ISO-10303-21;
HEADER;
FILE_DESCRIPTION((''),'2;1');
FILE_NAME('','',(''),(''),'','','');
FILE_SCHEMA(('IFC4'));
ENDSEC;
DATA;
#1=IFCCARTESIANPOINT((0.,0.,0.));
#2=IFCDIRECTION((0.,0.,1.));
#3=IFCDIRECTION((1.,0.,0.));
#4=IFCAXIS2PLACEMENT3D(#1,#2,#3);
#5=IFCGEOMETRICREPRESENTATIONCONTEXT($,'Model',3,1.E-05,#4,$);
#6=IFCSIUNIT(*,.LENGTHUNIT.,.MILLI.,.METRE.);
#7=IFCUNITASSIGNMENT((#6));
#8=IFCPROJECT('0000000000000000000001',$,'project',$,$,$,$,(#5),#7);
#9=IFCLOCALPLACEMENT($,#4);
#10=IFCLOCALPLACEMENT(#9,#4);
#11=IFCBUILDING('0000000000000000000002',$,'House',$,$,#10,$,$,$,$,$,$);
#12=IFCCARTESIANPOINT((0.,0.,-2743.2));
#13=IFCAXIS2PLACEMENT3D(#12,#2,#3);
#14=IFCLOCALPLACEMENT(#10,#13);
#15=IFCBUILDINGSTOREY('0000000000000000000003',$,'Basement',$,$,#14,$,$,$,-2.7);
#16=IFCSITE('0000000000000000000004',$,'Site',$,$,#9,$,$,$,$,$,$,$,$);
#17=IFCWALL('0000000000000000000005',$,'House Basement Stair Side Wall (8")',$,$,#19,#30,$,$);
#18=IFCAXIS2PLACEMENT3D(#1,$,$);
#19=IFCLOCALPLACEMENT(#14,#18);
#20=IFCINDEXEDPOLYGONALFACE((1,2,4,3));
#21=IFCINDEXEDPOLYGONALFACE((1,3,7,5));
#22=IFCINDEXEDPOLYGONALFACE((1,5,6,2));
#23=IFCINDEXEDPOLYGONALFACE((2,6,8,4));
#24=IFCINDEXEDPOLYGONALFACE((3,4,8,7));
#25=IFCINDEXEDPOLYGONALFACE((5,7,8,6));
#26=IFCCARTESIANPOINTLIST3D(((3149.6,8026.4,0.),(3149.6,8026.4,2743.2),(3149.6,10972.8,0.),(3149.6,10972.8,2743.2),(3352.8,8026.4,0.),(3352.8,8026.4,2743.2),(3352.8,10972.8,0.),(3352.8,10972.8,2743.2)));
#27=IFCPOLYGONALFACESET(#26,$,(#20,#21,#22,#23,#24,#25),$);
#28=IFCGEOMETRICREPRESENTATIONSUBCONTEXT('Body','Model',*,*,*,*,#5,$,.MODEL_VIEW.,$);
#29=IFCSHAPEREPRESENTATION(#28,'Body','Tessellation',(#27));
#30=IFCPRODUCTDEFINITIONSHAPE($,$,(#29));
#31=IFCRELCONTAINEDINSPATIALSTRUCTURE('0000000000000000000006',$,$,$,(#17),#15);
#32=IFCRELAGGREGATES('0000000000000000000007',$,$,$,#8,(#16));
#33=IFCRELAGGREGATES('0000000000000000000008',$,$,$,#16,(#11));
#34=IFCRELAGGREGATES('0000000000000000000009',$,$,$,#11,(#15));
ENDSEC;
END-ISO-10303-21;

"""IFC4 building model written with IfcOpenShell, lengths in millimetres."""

from ifc_helpers import new_model, si_unit, frame, origin_with_axes, place, context, subcontext, project, spatial, indexed_curve, outline, extrude, element, save


model = new_model("IFC4")

# Units and contexts
model_context = context("Model", 3, precision=1e-05, world=origin_with_axes())
body_context = subcontext(model_context, "Body", "Model", "MODEL_VIEW")
ifc_project = project(units=[si_unit("LENGTHUNIT", "METRE", prefix="MILLI")], contexts=[model_context])

# Site, building, storey
site_placement = place(None, origin_with_axes())
site = spatial("IfcSite", under=ifc_project, at=site_placement, Name="Site")
building_placement = place(site_placement, origin_with_axes())
building = spatial("IfcBuilding", under=site, at=building_placement, Name="House")
storey_placement = place(building_placement, frame((0.0, 0.0, -2743.2), z_axis=(0.0, 0.0, 1.0), x_axis=(1.0, 0.0, 0.0)))
storey = spatial("IfcBuildingStorey", under=building, at=storey_placement, Name="Basement", Elevation=-2.7)

# Wall
wall_1_placement = place(storey_placement, frame((3352.8, 8026.4, 0.0), z_axis=(0.0, 0.0, 1.0), x_axis=(0.0, 1.0, 0.0)))
element("IfcWall", 1, at=wall_1_placement, inside=storey, Name="House Basement Stair Side Wall (8\")", context=body_context, shape_type="SweptSolid", body=[
    extrude(outline(indexed_curve([(0.0, 0.0), (0.0, 203.2), (2946.4, 203.2), (2946.4, 0.0), (0.0, 0.0)], self_intersect=False)), origin_with_axes(), (0.0, 0.0, 1.0), 2743.2),
])

save(model, "model.ifc")
